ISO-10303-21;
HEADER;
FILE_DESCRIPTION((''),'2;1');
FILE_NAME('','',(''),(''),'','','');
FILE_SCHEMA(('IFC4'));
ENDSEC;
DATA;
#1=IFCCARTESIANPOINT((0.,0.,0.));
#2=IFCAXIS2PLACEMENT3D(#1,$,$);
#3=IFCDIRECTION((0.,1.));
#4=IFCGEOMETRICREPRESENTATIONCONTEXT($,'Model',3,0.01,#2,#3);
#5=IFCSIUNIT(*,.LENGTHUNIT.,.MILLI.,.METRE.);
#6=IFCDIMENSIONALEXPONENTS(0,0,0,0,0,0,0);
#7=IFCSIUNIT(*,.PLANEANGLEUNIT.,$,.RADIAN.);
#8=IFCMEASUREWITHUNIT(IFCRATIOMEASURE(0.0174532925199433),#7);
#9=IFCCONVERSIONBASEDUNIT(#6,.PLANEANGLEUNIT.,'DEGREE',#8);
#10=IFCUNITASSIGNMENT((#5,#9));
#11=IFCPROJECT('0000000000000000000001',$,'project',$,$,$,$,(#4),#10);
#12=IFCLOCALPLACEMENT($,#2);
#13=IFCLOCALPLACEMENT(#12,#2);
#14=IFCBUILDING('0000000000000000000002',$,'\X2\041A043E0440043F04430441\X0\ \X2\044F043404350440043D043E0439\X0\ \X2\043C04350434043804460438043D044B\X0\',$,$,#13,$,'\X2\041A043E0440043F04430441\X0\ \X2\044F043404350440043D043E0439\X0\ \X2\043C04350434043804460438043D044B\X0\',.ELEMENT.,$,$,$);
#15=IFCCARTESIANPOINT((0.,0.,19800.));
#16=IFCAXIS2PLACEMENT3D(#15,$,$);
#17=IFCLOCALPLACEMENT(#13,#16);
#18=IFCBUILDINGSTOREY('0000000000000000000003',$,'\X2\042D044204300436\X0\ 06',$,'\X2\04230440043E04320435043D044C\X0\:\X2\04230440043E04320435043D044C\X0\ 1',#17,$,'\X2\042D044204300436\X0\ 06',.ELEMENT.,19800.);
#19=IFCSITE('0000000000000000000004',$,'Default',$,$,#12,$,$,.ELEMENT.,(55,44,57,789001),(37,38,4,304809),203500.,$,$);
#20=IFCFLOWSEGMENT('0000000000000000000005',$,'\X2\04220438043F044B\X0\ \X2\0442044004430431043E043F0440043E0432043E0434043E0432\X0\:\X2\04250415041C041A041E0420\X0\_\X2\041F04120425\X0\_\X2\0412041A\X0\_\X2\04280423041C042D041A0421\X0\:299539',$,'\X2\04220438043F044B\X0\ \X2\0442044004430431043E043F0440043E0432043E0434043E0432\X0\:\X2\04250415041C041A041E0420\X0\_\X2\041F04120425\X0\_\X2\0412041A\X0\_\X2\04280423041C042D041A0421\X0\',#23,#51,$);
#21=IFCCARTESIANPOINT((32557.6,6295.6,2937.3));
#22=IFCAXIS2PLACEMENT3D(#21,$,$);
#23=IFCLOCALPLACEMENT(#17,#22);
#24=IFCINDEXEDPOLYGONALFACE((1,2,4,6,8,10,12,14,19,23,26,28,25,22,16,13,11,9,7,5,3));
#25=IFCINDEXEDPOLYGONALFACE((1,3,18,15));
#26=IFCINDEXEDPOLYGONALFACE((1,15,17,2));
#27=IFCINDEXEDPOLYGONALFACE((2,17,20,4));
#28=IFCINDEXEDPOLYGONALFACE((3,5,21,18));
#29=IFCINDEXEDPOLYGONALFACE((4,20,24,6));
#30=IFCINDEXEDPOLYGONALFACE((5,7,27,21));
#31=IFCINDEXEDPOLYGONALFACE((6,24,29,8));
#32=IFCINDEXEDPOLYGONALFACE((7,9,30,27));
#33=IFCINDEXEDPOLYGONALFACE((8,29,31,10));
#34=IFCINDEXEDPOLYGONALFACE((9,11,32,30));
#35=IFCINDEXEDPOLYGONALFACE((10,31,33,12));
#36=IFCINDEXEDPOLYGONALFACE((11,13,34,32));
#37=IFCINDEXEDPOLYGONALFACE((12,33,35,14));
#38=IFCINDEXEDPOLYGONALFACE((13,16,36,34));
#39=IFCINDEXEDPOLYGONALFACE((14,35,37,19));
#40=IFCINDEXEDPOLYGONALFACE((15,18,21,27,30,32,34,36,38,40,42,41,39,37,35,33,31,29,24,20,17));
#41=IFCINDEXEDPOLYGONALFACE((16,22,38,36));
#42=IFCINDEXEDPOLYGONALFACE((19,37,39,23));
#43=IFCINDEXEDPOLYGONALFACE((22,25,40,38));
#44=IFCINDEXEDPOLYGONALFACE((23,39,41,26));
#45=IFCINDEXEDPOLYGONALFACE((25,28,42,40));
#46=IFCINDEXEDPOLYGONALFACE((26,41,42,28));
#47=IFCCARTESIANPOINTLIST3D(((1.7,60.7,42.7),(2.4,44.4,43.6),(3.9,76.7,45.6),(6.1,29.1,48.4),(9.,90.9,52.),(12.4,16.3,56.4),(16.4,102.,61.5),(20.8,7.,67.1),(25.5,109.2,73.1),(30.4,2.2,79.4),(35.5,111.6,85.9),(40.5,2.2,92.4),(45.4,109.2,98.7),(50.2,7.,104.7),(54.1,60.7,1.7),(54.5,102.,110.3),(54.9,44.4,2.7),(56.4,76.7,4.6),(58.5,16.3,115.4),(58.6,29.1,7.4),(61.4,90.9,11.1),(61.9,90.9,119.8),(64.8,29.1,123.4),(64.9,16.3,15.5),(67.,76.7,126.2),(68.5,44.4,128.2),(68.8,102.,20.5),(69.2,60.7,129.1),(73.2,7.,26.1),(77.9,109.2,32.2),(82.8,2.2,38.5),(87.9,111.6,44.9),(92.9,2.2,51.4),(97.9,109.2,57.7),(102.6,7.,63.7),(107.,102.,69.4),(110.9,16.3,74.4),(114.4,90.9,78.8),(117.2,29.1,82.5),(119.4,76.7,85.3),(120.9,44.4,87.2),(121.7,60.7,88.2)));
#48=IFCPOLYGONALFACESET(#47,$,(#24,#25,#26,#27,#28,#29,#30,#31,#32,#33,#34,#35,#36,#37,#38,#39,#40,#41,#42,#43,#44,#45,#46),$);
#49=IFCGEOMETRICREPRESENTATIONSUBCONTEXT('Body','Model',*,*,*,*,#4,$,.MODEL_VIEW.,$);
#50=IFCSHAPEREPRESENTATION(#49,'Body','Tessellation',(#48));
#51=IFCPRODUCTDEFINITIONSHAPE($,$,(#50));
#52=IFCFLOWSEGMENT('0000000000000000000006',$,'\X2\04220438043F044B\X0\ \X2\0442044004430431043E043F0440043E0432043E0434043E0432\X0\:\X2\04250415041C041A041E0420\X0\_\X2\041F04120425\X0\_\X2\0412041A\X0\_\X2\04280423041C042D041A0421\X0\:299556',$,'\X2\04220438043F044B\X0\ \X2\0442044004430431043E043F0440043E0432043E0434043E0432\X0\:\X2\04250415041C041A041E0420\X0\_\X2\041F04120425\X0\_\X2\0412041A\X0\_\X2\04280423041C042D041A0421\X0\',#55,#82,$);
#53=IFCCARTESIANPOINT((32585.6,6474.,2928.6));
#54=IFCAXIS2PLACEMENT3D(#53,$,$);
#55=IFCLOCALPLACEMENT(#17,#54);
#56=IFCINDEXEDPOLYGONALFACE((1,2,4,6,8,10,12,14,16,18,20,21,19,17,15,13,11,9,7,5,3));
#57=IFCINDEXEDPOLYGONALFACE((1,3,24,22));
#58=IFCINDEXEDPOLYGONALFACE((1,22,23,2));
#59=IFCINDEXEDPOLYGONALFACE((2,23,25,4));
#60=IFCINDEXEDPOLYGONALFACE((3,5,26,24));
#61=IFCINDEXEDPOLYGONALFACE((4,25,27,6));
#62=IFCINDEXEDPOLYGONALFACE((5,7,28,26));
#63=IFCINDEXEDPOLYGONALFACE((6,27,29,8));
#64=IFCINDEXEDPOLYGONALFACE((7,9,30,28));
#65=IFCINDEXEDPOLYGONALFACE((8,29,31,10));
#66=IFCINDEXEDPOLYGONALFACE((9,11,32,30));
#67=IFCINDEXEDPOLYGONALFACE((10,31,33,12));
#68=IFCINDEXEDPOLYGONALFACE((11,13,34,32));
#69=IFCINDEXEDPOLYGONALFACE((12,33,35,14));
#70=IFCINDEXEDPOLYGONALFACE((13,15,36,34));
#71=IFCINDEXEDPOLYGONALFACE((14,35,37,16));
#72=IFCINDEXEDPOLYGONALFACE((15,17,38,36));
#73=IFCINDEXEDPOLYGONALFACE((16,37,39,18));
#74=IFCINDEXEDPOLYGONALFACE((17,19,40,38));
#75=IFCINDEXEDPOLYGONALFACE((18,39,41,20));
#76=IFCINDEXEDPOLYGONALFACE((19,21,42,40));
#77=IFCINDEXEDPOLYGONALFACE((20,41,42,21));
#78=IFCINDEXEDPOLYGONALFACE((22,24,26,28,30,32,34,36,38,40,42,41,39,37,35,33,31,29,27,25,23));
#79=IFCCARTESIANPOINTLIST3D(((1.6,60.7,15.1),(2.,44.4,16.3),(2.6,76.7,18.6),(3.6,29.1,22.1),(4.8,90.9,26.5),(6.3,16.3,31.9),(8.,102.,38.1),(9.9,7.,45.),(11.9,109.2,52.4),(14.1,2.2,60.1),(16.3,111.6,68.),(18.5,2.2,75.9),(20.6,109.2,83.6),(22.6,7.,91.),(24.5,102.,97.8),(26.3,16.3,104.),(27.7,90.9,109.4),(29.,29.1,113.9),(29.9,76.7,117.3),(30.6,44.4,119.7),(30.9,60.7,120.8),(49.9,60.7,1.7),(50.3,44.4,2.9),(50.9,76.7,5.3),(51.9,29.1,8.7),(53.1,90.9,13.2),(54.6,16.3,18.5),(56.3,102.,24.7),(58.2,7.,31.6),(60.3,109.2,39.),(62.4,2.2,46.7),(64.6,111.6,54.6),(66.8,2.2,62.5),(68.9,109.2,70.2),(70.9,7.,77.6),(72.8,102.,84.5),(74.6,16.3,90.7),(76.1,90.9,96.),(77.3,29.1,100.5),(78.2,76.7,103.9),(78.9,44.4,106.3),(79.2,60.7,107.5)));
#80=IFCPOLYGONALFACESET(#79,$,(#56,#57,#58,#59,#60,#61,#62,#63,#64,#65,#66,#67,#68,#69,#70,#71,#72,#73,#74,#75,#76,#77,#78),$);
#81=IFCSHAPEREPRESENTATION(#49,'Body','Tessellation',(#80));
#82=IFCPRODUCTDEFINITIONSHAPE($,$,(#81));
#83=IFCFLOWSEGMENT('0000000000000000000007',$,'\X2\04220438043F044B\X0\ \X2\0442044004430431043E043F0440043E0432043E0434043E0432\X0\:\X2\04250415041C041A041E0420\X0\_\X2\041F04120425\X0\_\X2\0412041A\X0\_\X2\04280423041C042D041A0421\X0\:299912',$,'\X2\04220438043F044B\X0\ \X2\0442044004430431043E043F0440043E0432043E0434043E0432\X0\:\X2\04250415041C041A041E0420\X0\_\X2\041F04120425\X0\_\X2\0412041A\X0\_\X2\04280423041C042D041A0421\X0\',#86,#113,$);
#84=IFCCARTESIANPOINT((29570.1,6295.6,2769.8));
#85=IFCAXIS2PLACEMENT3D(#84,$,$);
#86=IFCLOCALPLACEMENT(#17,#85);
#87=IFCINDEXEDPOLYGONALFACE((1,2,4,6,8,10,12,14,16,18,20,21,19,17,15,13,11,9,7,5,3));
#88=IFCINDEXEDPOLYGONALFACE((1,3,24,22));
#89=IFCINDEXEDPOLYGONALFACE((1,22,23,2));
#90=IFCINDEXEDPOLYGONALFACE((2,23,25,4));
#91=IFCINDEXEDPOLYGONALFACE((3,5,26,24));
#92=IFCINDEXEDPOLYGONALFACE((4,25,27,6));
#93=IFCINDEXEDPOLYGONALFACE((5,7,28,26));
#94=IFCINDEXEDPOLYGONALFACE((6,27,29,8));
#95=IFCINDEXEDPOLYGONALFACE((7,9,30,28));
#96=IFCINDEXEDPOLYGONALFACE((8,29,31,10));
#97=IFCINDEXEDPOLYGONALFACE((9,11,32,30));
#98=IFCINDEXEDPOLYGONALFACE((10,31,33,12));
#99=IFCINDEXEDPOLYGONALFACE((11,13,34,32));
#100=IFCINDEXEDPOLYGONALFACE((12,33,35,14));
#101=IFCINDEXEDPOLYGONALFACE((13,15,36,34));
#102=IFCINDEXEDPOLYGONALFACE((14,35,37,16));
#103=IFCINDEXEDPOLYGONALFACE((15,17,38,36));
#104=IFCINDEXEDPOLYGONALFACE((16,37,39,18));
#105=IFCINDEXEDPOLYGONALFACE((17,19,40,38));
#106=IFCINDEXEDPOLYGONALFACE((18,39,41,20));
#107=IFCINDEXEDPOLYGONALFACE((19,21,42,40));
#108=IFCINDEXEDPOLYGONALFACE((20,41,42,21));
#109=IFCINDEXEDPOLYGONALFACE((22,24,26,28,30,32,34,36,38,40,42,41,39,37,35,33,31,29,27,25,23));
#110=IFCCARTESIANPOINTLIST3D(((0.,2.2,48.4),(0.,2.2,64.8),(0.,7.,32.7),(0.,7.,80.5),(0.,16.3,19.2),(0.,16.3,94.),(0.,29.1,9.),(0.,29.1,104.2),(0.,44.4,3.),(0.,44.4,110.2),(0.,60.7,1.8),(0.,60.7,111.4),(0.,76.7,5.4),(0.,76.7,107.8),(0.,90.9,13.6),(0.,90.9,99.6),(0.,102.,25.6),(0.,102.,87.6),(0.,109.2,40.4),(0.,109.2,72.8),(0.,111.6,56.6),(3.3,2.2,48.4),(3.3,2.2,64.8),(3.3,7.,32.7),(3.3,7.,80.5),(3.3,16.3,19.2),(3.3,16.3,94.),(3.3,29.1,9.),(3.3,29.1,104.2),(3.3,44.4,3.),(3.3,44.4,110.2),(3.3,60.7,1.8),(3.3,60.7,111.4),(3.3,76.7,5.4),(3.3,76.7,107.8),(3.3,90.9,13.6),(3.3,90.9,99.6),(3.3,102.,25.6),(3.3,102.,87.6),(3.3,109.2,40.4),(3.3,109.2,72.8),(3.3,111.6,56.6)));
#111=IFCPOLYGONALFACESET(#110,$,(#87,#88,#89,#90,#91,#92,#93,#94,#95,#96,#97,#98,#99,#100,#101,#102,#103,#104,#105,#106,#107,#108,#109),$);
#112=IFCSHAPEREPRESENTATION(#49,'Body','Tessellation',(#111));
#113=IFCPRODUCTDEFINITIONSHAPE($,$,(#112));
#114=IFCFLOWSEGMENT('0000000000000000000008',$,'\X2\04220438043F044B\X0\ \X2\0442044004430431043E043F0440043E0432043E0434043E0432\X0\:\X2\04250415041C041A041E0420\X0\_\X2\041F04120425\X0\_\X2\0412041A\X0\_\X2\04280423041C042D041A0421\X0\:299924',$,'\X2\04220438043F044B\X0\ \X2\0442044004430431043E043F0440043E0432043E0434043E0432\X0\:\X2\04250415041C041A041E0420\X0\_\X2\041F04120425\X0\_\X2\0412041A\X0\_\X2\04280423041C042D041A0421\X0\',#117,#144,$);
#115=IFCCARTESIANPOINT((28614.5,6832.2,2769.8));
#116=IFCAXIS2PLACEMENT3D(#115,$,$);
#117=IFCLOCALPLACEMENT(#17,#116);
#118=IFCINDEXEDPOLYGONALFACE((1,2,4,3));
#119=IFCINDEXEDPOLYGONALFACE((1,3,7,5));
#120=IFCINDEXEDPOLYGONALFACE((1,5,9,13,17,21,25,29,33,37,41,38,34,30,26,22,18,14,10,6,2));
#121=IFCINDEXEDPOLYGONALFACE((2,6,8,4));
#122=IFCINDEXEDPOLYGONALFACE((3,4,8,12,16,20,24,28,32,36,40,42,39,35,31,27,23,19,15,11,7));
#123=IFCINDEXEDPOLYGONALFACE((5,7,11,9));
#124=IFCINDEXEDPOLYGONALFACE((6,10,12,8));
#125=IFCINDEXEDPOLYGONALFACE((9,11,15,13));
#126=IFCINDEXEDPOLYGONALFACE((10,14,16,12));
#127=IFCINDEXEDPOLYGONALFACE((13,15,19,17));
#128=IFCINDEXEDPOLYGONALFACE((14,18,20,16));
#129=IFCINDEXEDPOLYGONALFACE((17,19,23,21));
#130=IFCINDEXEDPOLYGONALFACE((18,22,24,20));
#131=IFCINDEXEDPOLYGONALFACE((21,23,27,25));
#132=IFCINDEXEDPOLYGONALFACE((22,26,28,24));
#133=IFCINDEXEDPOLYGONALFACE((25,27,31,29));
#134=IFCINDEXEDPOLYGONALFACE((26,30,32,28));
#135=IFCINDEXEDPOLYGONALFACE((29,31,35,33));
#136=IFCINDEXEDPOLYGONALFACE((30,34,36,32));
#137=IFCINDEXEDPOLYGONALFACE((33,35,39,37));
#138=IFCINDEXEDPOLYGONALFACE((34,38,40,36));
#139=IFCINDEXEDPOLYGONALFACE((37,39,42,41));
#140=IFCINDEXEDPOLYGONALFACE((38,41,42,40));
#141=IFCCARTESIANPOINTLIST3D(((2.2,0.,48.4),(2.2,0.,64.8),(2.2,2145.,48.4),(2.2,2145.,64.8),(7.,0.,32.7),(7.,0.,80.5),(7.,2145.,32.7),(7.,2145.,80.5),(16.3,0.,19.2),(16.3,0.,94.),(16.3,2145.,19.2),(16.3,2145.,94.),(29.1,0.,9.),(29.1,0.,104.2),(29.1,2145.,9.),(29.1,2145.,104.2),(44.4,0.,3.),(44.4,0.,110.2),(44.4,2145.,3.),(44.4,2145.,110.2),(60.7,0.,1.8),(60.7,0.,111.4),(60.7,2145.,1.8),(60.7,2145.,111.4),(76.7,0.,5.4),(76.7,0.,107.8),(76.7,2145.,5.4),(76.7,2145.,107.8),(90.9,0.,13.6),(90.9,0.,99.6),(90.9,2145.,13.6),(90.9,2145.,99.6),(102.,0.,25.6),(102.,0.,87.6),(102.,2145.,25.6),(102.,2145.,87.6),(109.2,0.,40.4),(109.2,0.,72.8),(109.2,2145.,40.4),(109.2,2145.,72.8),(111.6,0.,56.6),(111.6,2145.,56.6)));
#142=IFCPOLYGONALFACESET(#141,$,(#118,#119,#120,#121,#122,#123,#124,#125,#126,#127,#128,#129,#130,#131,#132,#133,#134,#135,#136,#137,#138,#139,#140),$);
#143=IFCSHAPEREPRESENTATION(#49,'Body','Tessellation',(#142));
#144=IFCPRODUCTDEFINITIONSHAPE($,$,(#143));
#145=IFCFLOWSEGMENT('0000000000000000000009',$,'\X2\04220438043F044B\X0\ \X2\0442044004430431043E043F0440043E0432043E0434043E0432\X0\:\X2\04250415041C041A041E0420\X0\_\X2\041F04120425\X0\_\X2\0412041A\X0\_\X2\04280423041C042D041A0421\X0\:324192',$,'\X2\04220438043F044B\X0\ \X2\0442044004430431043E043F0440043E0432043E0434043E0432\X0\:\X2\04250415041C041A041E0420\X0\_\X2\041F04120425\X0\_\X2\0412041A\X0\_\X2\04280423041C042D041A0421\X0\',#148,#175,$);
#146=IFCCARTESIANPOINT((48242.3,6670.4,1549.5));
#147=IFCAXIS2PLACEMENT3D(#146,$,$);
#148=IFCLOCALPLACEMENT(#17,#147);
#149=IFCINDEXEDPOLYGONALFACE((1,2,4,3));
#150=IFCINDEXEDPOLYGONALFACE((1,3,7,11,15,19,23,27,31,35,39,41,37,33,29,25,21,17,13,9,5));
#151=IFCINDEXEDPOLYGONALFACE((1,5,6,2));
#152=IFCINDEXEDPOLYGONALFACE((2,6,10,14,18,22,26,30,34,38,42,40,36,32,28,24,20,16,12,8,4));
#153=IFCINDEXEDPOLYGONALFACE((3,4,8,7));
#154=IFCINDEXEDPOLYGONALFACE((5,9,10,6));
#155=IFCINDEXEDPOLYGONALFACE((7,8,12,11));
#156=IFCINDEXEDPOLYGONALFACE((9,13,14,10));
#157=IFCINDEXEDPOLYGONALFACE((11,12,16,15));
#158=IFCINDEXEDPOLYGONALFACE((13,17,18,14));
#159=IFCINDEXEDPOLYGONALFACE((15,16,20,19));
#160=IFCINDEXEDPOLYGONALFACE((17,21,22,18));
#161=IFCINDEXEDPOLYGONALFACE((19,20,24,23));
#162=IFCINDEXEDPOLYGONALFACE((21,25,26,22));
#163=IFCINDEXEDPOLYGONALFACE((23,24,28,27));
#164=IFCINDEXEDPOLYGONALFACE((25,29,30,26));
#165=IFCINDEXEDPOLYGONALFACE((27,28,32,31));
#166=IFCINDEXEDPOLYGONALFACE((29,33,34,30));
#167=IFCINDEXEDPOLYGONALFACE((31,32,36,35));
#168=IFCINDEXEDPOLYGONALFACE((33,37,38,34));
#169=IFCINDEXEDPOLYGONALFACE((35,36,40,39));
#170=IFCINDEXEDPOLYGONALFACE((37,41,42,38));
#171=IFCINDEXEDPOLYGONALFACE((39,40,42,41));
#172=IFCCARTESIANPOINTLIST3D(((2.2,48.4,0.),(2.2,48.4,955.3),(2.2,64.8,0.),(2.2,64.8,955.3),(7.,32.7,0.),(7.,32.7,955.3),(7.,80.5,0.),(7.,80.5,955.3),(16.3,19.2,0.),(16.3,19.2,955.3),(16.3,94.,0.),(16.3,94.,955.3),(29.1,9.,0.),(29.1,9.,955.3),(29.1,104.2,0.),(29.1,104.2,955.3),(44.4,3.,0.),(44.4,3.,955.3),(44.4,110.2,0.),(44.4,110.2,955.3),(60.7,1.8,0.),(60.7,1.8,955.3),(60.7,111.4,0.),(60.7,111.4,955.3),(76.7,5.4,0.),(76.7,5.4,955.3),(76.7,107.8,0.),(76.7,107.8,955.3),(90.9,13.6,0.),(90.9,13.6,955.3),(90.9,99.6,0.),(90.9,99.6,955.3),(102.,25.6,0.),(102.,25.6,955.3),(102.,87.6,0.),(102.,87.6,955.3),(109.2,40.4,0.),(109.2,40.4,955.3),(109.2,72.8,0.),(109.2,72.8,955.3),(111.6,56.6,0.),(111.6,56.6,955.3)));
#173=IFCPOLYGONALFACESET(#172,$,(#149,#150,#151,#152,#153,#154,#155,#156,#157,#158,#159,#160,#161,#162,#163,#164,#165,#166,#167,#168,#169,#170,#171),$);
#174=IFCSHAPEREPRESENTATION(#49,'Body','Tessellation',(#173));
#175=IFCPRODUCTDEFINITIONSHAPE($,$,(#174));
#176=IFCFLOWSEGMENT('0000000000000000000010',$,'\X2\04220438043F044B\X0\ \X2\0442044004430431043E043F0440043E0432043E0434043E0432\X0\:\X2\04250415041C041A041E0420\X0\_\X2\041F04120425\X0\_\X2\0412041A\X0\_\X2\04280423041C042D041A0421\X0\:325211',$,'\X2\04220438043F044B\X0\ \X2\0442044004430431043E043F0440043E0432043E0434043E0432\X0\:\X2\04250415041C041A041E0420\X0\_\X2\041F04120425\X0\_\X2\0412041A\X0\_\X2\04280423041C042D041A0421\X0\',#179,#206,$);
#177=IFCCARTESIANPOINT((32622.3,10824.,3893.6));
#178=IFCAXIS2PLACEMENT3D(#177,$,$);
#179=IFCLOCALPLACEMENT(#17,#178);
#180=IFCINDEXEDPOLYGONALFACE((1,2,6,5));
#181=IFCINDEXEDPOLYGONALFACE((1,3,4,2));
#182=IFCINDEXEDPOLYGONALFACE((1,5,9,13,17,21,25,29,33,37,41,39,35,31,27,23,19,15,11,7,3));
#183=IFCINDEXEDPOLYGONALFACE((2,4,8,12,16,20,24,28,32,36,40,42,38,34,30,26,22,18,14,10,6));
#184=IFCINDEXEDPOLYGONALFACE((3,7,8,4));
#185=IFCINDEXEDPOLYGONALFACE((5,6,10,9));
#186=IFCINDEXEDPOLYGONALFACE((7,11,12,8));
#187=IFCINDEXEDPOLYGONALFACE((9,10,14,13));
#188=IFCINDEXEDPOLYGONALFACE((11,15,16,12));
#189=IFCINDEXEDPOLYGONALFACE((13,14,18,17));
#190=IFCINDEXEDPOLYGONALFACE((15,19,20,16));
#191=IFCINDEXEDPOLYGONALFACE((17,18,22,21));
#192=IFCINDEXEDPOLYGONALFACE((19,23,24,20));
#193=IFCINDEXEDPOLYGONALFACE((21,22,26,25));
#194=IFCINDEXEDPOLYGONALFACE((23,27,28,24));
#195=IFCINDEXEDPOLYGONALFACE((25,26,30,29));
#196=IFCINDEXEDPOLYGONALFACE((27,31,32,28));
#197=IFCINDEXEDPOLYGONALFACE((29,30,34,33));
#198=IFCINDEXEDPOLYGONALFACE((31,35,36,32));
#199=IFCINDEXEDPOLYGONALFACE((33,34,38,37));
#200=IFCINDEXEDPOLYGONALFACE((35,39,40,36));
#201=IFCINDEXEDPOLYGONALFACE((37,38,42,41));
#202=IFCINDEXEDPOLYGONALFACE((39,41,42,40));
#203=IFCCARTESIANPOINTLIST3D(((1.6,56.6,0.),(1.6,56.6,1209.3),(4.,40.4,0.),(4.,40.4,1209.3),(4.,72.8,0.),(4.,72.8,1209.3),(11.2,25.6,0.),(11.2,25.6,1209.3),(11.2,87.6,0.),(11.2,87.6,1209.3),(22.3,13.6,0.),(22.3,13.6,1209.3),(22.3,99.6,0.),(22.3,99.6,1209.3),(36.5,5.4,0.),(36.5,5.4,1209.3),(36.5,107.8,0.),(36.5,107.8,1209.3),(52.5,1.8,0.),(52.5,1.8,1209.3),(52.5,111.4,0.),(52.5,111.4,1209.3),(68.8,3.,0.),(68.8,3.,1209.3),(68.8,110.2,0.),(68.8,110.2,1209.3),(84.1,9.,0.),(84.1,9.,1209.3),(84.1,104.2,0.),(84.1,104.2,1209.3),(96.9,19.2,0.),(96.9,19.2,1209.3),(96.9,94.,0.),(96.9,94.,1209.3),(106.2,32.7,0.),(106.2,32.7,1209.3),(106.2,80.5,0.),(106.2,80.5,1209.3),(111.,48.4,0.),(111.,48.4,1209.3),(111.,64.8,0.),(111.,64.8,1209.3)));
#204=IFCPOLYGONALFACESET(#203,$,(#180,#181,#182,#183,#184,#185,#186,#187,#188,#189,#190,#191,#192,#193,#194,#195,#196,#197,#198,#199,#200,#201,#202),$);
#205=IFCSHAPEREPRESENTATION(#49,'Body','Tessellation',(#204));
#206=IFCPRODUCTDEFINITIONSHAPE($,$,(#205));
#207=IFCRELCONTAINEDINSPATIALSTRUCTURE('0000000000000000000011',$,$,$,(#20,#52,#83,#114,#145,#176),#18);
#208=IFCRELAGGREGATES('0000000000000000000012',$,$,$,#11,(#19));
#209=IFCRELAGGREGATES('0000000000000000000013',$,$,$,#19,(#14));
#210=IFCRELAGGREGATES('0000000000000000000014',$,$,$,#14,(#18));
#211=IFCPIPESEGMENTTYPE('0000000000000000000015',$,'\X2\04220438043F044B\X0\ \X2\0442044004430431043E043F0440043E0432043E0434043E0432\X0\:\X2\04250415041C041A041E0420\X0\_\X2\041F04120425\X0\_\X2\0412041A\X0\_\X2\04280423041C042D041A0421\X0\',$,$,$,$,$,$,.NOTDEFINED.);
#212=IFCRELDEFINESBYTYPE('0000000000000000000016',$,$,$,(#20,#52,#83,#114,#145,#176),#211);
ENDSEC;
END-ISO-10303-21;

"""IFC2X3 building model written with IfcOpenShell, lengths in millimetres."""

from ifc_helpers import new_model, entity, si_unit, converted_unit, direction, frame, origin, origin_2d_with_axis, place, context, subcontext, project, spatial, circle, extrude, type_object, element, save


model = new_model("IFC2X3")

# Units and contexts
model_context = context("Model", 3, precision=0.01, world=origin(), true_north=direction((0.0, 1.0)))
body_context = subcontext(model_context, "Body", "Model", "MODEL_VIEW")
ifc_project = project(units=[si_unit("LENGTHUNIT", "METRE", prefix="MILLI"), converted_unit("PLANEANGLEUNIT", "DEGREE", entity("IfcRatioMeasure", 0.0174532925199433), si_unit("PLANEANGLEUNIT", "RADIAN"), dimensions=[0, 0, 0, 0, 0, 0, 0])], contexts=[model_context])

# Site, building, storey
site_placement = place(None, origin())
site = spatial("IfcSite", under=ifc_project, at=site_placement, Name="Default", CompositionType="ELEMENT", RefLatitude=(55, 44, 57, 789001), RefLongitude=(37, 38, 4, 304809), RefElevation=203500.0)
building_placement = place(site_placement, origin())
building = spatial("IfcBuilding", under=site, at=building_placement, Name="Корпус ядерной медицины", LongName="Корпус ядерной медицины", CompositionType="ELEMENT")
storey_placement = place(building_placement, frame((0.0, 0.0, 19800.0)))
storey = spatial("IfcBuildingStorey", under=building, at=storey_placement, Name="Этаж 06", ObjectType="Уровень:Уровень 1", LongName="Этаж 06", CompositionType="ELEMENT", Elevation=19800.0)

# Flow segments
pipe_segment_type = type_object("IfcPipeSegmentType", Name="Типы трубопроводов:ХЕМКОР_ПВХ_ВК_ШУМЭКС", PredefinedType="NOTDEFINED")
flow_segment_1_placement = place(storey_placement, frame((32557.6, 6295.6, 2937.3)))
element("IfcFlowSegment", 1, at=flow_segment_1_placement, inside=storey, type_object=pipe_segment_type, Name="Типы трубопроводов:ХЕМКОР_ПВХ_ВК_ШУМЭКС:299539", ObjectType="Типы трубопроводов:ХЕМКОР_ПВХ_ВК_ШУМЭКС", context=body_context, shape_type="SweptSolid", body=[
    extrude(circle(Radius=55.0, at=origin_2d_with_axis()), frame((35.5, 56.6, 85.9), z_axis=(0.788022, 0.0, -0.615647), x_axis=(0.0, 1.0, 0.0)), (0.0, 0.0, 1.0), 66.5),
])
flow_segment_2_placement = place(storey_placement, frame((32585.6, 6474.0, 2928.6)))
element("IfcFlowSegment", 2, at=flow_segment_2_placement, inside=storey, type_object=pipe_segment_type, Name="Типы трубопроводов:ХЕМКОР_ПВХ_ВК_ШУМЭКС:299556", ObjectType="Типы трубопроводов:ХЕМКОР_ПВХ_ВК_ШУМЭКС", context=body_context, shape_type="SweptSolid", body=[
    extrude(circle(Radius=55.0, at=origin_2d_with_axis()), frame((64.6, 56.6, 54.6), z_axis=(-0.963736, 0.0, 0.266857), x_axis=(0.0, 1.0, 0.0)), (0.0, 0.0, 1.0), 50.1),
])
flow_segment_3_placement = place(storey_placement, frame((29570.1, 6295.6, 2769.8)))
element("IfcFlowSegment", 3, at=flow_segment_3_placement, inside=storey, type_object=pipe_segment_type, Name="Типы трубопроводов:ХЕМКОР_ПВХ_ВК_ШУМЭКС:299912", ObjectType="Типы трубопроводов:ХЕМКОР_ПВХ_ВК_ШУМЭКС", context=body_context, shape_type="SweptSolid", body=[
    extrude(circle(Radius=55.0, at=origin_2d_with_axis()), frame((0.0, 56.6, 56.6), z_axis=(1.0, 0.0, 0.0), x_axis=(0.0, 1.0, 0.0)), (0.0, 0.0, 1.0), 3.3),
])
flow_segment_4_placement = place(storey_placement, frame((28614.5, 6832.2, 2769.8)))
element("IfcFlowSegment", 4, at=flow_segment_4_placement, inside=storey, type_object=pipe_segment_type, Name="Типы трубопроводов:ХЕМКОР_ПВХ_ВК_ШУМЭКС:299924", ObjectType="Типы трубопроводов:ХЕМКОР_ПВХ_ВК_ШУМЭКС", context=body_context, shape_type="SweptSolid", body=[
    extrude(circle(Radius=55.0, at=origin_2d_with_axis()), frame((56.6, 0.0, 56.6), z_axis=(0.0, 1.0, 0.0), x_axis=(1.0, 0.0, 0.0)), (0.0, 0.0, 1.0), 2145.0),
])
flow_segment_5_placement = place(storey_placement, frame((48242.3, 6670.4, 1549.5)))
element("IfcFlowSegment", 5, at=flow_segment_5_placement, inside=storey, type_object=pipe_segment_type, Name="Типы трубопроводов:ХЕМКОР_ПВХ_ВК_ШУМЭКС:324192", ObjectType="Типы трубопроводов:ХЕМКОР_ПВХ_ВК_ШУМЭКС", context=body_context, shape_type="SweptSolid", body=[
    extrude(circle(Radius=55.0, at=origin_2d_with_axis()), frame((56.6, 56.6, 0.0)), (0.0, 0.0, 1.0), 955.3),
])
flow_segment_6_placement = place(storey_placement, frame((32622.3, 10824.0, 3893.6)))
element("IfcFlowSegment", 6, at=flow_segment_6_placement, inside=storey, type_object=pipe_segment_type, Name="Типы трубопроводов:ХЕМКОР_ПВХ_ВК_ШУМЭКС:325211", ObjectType="Типы трубопроводов:ХЕМКОР_ПВХ_ВК_ШУМЭКС", context=body_context, shape_type="SweptSolid", body=[
    extrude(circle(Radius=55.0, at=origin_2d_with_axis()), frame((56.6, 56.6, 0.0), z_axis=(0.0, 0.0, 1.0), x_axis=(-1.0, 0.0, 0.0)), (0.0, 0.0, 1.0), 1209.3),
])

save(model, "model.ifc")
